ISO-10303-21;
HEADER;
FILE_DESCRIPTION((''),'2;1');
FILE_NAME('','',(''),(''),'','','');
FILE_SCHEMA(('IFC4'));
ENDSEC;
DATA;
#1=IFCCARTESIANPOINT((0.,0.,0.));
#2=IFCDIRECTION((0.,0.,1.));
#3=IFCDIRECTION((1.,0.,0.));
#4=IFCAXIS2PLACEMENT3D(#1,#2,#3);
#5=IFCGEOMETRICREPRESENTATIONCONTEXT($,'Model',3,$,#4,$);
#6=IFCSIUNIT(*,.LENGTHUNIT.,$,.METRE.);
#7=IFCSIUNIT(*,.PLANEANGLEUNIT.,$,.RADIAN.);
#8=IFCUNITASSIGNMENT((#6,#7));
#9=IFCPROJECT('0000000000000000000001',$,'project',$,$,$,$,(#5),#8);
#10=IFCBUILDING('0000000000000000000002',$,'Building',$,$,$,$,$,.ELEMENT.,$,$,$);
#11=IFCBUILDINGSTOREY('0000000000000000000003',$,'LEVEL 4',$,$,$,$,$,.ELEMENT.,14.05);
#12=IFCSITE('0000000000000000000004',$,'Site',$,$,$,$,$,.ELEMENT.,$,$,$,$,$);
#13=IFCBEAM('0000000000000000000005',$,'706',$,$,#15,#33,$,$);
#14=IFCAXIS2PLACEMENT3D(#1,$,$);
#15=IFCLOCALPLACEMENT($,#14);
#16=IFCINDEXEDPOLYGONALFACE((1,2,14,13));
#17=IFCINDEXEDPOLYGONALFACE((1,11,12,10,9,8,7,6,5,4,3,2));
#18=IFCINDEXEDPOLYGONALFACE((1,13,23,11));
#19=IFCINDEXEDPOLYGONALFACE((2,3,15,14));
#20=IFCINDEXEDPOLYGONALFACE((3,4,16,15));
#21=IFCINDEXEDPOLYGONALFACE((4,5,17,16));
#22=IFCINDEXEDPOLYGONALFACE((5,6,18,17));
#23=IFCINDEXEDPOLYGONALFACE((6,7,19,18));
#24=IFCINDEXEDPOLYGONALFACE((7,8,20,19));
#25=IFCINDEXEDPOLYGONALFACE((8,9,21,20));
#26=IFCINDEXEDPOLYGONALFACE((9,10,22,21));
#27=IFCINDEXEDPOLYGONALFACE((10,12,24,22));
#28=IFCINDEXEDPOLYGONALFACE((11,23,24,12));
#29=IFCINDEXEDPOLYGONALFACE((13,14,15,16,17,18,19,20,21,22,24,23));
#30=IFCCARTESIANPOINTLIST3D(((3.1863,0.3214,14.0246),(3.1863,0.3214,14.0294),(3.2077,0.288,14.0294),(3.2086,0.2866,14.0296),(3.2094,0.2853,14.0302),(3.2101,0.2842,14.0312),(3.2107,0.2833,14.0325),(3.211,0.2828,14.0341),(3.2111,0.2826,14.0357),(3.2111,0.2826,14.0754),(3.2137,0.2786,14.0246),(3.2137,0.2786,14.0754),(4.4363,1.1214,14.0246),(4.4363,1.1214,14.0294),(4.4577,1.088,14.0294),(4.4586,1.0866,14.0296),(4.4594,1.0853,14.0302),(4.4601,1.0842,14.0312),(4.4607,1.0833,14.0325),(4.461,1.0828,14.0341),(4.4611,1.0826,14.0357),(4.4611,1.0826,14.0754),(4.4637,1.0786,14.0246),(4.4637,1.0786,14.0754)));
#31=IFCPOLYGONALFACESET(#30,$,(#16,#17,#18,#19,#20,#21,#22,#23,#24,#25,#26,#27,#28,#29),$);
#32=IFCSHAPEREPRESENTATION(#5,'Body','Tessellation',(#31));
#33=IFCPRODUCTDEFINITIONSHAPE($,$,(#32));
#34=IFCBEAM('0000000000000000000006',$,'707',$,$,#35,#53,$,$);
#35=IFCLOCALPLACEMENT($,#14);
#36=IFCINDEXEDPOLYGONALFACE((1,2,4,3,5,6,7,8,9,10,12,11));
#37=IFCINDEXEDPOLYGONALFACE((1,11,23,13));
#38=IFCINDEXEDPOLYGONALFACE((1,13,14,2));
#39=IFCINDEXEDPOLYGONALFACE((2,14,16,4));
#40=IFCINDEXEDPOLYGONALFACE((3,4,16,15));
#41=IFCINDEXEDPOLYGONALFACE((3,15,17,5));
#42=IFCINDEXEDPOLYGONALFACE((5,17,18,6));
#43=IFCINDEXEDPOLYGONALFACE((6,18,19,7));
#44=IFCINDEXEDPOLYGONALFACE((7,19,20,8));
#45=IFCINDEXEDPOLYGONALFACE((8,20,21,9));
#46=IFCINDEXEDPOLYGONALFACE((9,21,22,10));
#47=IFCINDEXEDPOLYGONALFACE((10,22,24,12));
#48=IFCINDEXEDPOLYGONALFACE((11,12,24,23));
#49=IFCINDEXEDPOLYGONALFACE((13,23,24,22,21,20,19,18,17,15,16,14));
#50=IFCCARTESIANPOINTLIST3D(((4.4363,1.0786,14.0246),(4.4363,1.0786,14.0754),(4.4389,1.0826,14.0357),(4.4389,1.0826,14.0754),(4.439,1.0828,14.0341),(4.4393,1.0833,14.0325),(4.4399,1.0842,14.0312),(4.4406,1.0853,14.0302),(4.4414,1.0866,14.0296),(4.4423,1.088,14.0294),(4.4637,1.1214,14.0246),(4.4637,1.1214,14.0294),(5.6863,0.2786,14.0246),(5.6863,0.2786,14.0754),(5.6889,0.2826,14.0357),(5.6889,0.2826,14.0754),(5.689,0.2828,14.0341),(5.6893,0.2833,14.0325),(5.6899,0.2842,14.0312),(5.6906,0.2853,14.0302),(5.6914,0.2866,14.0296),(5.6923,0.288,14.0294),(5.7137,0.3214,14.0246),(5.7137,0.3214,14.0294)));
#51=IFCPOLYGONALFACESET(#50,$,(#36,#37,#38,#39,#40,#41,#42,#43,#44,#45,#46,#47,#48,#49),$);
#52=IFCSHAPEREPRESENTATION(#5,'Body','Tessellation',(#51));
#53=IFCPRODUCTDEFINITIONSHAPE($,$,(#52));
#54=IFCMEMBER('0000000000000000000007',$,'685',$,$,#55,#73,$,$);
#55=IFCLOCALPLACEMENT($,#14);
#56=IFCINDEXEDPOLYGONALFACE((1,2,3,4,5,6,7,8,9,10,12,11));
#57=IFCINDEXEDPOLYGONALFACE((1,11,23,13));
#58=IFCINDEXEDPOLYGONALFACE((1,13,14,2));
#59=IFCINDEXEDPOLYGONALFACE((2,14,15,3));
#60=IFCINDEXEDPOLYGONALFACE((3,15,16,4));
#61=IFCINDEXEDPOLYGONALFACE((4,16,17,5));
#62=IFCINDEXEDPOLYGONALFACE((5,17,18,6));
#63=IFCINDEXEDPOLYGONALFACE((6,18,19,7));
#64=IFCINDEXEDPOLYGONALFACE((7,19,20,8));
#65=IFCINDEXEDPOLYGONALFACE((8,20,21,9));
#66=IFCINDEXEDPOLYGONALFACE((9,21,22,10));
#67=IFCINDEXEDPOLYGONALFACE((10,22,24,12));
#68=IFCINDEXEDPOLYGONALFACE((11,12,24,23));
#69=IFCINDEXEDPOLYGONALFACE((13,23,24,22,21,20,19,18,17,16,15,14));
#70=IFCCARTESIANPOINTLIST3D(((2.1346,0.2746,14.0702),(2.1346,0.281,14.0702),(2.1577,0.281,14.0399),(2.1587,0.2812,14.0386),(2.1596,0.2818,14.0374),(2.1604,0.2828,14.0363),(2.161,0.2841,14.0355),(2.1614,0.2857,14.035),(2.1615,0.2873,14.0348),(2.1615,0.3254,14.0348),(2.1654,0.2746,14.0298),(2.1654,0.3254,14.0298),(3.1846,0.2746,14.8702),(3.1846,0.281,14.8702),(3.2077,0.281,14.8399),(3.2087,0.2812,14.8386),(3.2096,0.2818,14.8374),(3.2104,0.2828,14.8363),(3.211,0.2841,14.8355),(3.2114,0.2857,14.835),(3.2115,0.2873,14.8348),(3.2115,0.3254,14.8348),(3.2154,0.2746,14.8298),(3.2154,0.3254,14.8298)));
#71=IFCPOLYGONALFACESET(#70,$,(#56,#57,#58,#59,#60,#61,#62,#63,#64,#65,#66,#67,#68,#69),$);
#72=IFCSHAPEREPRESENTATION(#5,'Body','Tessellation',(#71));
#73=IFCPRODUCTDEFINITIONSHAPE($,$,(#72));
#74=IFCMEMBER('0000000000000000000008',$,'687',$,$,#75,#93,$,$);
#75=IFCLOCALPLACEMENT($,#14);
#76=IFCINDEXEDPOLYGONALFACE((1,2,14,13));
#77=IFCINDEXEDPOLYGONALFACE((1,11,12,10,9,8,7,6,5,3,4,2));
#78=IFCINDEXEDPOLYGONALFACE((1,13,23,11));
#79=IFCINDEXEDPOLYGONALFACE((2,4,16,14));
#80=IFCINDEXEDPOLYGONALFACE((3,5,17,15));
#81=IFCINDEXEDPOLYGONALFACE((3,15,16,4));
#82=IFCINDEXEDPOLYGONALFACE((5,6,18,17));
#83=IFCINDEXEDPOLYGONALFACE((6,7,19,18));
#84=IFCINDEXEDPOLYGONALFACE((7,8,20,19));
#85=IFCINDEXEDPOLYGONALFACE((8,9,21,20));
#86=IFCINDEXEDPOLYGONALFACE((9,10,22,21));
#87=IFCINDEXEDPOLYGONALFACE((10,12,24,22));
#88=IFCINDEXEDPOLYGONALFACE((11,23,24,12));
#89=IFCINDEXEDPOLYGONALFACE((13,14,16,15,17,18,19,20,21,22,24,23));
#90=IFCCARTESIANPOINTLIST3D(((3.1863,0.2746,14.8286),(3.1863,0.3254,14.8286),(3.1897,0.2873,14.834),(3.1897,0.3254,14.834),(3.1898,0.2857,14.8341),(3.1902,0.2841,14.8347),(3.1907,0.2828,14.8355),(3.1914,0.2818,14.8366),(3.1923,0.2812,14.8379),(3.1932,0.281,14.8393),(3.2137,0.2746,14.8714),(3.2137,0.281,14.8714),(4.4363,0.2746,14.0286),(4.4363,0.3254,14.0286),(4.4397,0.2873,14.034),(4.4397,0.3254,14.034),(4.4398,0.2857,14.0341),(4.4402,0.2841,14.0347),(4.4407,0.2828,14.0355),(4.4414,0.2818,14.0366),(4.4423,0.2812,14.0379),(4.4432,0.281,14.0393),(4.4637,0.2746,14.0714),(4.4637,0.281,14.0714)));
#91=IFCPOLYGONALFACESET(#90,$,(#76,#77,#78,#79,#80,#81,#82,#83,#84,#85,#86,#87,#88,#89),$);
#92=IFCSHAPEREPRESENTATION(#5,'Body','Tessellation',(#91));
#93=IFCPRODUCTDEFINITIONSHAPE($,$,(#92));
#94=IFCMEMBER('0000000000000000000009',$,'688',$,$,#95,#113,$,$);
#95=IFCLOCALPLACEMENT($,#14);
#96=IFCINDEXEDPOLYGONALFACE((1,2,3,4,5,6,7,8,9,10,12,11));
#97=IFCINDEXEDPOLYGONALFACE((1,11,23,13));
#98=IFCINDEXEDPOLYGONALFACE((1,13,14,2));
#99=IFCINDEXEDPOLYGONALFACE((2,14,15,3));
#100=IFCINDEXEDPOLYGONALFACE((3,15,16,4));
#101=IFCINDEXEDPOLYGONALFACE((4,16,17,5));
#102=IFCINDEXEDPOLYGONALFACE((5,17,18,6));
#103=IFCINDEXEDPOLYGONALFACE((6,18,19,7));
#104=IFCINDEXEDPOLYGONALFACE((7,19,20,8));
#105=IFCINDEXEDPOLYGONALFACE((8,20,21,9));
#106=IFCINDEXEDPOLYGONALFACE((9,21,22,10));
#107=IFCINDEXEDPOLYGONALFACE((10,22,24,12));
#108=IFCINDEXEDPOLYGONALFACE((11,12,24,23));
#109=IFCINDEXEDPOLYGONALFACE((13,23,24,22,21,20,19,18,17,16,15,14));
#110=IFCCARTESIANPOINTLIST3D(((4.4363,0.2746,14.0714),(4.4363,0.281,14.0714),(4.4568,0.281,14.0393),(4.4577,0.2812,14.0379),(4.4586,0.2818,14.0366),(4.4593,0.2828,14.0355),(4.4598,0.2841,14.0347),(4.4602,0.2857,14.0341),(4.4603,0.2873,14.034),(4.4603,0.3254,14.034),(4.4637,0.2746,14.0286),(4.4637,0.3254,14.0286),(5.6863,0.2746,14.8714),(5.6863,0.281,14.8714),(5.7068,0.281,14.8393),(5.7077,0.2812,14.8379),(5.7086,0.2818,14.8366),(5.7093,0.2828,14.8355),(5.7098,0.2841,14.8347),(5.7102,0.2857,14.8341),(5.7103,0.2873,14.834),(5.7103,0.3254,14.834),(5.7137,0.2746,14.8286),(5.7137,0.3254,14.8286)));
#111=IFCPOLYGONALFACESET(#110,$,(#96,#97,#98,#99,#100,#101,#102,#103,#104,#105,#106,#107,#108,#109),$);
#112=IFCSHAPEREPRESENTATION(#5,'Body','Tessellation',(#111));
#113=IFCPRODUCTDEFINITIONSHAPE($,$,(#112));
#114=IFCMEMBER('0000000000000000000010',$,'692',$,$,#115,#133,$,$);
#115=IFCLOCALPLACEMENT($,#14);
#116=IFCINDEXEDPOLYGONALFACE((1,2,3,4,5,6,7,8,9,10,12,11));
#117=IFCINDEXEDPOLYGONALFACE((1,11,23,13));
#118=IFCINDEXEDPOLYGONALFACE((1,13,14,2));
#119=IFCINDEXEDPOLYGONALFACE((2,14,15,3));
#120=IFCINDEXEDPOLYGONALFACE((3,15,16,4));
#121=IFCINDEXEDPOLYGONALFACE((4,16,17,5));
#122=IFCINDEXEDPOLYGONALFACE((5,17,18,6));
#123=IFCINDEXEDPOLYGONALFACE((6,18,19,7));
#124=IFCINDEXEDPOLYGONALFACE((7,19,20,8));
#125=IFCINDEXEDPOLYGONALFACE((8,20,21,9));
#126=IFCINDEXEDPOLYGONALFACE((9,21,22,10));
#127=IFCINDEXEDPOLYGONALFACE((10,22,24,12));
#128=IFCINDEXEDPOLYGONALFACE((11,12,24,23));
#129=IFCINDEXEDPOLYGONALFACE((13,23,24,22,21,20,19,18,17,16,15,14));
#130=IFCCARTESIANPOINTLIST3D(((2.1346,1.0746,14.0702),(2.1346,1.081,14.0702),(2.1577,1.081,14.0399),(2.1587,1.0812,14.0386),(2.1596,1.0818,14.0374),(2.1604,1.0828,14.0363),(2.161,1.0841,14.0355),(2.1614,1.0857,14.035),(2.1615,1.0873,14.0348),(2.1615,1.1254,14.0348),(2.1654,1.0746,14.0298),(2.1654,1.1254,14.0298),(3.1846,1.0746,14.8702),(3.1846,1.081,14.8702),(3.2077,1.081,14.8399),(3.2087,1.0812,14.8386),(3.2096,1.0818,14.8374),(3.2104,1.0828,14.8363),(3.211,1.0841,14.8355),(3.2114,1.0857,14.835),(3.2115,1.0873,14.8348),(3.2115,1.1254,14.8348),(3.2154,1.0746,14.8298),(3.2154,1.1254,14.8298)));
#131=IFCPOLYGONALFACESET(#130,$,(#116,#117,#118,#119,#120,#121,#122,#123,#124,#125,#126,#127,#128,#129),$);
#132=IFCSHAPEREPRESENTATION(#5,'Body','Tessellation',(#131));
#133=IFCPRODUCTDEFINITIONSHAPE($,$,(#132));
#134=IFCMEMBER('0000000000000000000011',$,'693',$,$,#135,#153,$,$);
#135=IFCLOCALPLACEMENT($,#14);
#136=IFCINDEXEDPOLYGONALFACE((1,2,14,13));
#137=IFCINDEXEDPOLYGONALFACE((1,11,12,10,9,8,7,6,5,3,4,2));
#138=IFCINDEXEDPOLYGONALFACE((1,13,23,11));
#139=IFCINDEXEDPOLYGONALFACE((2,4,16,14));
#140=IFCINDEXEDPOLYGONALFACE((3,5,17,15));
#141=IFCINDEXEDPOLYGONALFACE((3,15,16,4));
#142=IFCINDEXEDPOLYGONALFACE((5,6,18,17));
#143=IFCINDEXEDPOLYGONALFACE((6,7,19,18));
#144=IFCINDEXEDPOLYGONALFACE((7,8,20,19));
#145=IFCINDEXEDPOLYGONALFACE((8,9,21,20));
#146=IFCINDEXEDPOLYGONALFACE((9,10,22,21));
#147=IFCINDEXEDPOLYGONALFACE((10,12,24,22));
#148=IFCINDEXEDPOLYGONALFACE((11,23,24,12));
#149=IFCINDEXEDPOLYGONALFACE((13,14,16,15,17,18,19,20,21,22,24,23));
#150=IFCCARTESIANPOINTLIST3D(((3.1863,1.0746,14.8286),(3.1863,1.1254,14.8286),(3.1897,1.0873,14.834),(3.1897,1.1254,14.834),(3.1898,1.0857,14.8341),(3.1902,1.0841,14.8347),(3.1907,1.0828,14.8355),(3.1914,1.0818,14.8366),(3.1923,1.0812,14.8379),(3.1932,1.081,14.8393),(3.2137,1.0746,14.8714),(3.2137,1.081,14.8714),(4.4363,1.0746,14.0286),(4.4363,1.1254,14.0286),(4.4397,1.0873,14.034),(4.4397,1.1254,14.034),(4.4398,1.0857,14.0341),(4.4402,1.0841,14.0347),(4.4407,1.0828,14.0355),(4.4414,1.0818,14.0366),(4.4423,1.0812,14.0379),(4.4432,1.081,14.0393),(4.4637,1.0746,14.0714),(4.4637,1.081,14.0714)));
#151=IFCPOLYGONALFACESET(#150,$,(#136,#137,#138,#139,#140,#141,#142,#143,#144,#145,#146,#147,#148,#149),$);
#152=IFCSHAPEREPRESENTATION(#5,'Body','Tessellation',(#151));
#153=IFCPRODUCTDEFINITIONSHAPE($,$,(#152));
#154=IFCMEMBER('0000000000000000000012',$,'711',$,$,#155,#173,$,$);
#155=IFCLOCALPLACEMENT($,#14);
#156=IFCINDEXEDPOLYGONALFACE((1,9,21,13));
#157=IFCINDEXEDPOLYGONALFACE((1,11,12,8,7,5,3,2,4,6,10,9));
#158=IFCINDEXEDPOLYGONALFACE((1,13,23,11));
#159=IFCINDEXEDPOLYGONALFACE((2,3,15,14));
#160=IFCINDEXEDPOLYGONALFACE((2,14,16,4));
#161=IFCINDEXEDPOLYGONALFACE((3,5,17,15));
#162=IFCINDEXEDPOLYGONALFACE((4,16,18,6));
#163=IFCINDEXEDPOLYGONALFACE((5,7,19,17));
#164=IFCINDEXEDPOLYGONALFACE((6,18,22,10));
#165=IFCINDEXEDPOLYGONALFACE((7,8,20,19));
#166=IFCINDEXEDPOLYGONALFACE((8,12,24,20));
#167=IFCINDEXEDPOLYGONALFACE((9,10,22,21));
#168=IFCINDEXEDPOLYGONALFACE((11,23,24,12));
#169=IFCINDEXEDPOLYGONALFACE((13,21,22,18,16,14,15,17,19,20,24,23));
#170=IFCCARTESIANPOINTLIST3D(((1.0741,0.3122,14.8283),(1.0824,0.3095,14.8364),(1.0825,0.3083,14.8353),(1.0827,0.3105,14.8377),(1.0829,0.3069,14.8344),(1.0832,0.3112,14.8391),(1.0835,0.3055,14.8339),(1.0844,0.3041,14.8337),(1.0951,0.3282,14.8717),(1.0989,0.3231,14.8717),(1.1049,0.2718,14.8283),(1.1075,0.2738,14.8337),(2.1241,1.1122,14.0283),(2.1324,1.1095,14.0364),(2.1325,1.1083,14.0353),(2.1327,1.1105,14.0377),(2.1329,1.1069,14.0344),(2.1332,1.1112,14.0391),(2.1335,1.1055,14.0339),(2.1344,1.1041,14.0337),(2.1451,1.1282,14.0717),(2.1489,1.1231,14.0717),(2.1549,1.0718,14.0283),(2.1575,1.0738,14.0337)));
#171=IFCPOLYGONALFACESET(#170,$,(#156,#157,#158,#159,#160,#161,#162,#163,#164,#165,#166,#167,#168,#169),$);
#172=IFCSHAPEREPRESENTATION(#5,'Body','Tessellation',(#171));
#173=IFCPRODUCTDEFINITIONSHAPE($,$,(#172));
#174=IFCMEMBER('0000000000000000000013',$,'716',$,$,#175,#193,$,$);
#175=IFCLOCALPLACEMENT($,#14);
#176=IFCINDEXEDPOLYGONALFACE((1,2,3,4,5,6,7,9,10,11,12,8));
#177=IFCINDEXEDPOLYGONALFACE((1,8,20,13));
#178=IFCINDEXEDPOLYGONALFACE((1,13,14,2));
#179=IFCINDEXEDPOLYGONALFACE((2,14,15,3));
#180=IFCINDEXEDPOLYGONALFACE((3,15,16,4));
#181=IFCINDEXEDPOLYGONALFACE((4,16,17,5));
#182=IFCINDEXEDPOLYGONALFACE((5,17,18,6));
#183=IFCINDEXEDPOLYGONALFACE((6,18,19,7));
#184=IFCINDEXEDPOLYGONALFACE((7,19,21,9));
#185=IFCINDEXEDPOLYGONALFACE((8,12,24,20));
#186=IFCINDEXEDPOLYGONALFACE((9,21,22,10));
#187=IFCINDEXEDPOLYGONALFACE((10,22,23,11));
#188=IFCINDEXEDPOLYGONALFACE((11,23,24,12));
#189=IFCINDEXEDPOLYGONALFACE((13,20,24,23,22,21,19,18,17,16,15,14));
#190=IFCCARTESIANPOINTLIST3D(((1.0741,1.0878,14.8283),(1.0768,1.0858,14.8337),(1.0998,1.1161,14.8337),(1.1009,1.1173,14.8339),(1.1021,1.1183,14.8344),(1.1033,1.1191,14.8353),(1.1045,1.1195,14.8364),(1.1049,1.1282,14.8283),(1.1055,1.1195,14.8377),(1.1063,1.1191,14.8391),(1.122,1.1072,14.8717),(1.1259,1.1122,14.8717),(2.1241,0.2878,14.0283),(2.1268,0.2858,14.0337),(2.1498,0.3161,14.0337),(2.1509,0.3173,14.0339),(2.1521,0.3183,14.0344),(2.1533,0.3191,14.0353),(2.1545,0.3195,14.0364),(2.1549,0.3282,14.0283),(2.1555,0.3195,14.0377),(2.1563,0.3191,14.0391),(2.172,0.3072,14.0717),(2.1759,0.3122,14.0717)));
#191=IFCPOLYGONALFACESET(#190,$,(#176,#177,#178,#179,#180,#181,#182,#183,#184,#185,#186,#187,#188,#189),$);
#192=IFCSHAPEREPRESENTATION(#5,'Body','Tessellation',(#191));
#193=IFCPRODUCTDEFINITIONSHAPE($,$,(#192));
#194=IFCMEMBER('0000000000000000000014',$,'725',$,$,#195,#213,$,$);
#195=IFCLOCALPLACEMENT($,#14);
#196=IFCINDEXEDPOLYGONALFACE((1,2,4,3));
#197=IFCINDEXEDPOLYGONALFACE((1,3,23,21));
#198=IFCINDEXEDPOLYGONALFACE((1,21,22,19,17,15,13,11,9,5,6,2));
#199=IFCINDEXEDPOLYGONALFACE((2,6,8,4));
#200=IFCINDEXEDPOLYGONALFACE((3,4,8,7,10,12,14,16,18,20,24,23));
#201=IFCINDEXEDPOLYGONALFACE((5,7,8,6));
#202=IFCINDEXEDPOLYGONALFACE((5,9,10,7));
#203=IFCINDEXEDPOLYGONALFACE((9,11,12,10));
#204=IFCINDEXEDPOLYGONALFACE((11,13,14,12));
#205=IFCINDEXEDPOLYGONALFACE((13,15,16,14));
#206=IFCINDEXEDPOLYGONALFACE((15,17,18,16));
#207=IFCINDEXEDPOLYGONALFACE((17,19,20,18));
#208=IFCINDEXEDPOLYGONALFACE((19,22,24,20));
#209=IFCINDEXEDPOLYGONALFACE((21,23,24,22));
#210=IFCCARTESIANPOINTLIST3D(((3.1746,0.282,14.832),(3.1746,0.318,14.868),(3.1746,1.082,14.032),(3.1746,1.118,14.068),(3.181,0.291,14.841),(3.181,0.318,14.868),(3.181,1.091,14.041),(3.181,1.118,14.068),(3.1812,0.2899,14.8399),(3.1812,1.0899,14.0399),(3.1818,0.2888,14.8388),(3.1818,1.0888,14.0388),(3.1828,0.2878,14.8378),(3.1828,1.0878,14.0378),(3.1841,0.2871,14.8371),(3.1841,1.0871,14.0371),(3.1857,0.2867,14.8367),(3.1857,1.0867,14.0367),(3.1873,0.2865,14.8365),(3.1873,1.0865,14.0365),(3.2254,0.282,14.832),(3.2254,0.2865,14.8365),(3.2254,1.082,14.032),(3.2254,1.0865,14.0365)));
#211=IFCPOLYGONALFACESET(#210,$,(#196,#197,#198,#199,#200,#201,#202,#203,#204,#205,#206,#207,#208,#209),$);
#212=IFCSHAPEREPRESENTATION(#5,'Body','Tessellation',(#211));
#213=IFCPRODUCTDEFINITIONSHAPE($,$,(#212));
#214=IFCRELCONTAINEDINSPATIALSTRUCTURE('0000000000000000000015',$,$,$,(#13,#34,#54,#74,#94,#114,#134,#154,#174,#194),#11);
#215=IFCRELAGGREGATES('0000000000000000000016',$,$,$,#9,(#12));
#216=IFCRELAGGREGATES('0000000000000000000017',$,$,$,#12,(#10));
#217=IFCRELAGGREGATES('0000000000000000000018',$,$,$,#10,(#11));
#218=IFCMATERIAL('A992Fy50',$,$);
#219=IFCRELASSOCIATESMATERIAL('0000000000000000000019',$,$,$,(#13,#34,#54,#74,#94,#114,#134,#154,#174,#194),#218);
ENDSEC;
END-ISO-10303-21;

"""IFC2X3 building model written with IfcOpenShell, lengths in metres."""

from ifc_helpers import new_model, si_unit, frame, origin_with_axes, origin_2d_with_axis, place, context, project, spatial, l_section, extrude, material, element, save


model = new_model("IFC2X3")

# Units and contexts
model_context = context("Model", 3, world=origin_with_axes())
ifc_project = project(units=[si_unit("LENGTHUNIT", "METRE"), si_unit("PLANEANGLEUNIT", "RADIAN")], contexts=[model_context])

# Site, building, storey
site = spatial("IfcSite", under=ifc_project, Name="Site", CompositionType="ELEMENT")
building = spatial("IfcBuilding", under=site, Name="Building", CompositionType="ELEMENT")
storey = spatial("IfcBuildingStorey", under=building, Name="LEVEL 4", CompositionType="ELEMENT", Elevation=14.05)

# Shared definitions
ifc_material = material(Name="A992Fy50")

# Beams
for number, where, z_axis, x_axis, name in (
    (1, (3.2, 0.3, 14.05), (0.842271, 0.539054, 0.0), (-0.539054, 0.842271, 0.0), "706"),
    (2, (4.45, 1.1, 14.05), (0.842271, -0.539054, 0.0), (0.539054, 0.842271, 0.0), "707"),
):
    element("IfcBeam", number, at=place(None, frame(where, z_axis=z_axis, x_axis=x_axis)), inside=storey, material=ifc_material, Name=name, context=model_context, shape_type="SweptSolid", body=[
        extrude(l_section(Depth=0.0508, Width=0.0508, Thickness=0.0048, FilletRadius=0.0063, at=origin_2d_with_axis()), origin_with_axes(), (0.0, 0.0, 1.0), 1.4841),
    ])

# Members
member_1_placement = place(None, frame((2.15, 0.3, 14.05), z_axis=(0.795432, 0.0, 0.606043), x_axis=(0.0, 1.0, 0.0)))
element("IfcMember", 3, at=member_1_placement, inside=storey, material=ifc_material, Name="685", context=model_context, shape_type="SweptSolid", body=[
    extrude(l_section(Depth=0.0508, Width=0.0508, Thickness=0.0063, FilletRadius=0.0063, at=origin_2d_with_axis()), origin_with_axes(), (0.0, 0.0, 1.0), 1.32),
])
for number, where, z_axis, x_axis, name in (
    (4, (3.2, 0.3, 14.85), (0.842271, 0.0, -0.539054), (0.0, 1.0, 0.0), "687"),
    (5, (4.45, 0.3, 14.05), (0.842271, 0.0, 0.539054), (0.0, 1.0, 0.0), "688"),
):
    element("IfcMember", number, at=place(None, frame(where, z_axis=z_axis, x_axis=x_axis)), inside=storey, material=ifc_material, Name=name, context=model_context, shape_type="SweptSolid", body=[
        extrude(l_section(Depth=0.0508, Width=0.0508, Thickness=0.0063, FilletRadius=0.0063, at=origin_2d_with_axis()), origin_with_axes(), (0.0, 0.0, 1.0), 1.4841),
    ])
member_2_placement = place(None, frame((2.15, 1.1, 14.05), z_axis=(0.795432, 0.0, 0.606043), x_axis=(0.0, 1.0, 0.0)))
element("IfcMember", 6, at=member_2_placement, inside=storey, material=ifc_material, Name="692", context=model_context, shape_type="SweptSolid", body=[
    extrude(l_section(Depth=0.0508, Width=0.0508, Thickness=0.0063, FilletRadius=0.0063, at=origin_2d_with_axis()), origin_with_axes(), (0.0, 0.0, 1.0), 1.32),
])
member_3_placement = place(None, frame((3.2, 1.1, 14.85), z_axis=(0.842271, 0.0, -0.539054), x_axis=(0.0, 1.0, 0.0)))
element("IfcMember", 7, at=member_3_placement, inside=storey, material=ifc_material, Name="693", context=model_context, shape_type="SweptSolid", body=[
    extrude(l_section(Depth=0.0508, Width=0.0508, Thickness=0.0063, FilletRadius=0.0063, at=origin_2d_with_axis()), origin_with_axes(), (0.0, 0.0, 1.0), 1.4841),
])
for number, where, z_axis, x_axis, name in (
    (8, (2.15, 1.1, 14.05), (-0.680257, -0.518291, 0.518291), (0.606043, -0.795432, 0.0), "711"),
    (9, (2.15, 0.3, 14.05), (-0.680257, 0.518291, 0.518291), (-0.606043, -0.795432, 0.0), "716"),
):
    element("IfcMember", number, at=place(None, frame(where, z_axis=z_axis, x_axis=x_axis)), inside=storey, material=ifc_material, Name=name, context=model_context, shape_type="SweptSolid", body=[
        extrude(l_section(Depth=0.0508, Width=0.0508, Thickness=0.0063, FilletRadius=0.0063, at=origin_2d_with_axis()), origin_with_axes(), (0.0, 0.0, 1.0), 1.5435),
    ])
for number, where, z_axis, x_axis, name in (
    (10, (3.2, 1.1, 14.05), (0.0, -0.707107, 0.707107), (1.0, 0.0, 0.0), "725"),
):
    element("IfcMember", number, at=place(None, frame(where, z_axis=z_axis, x_axis=x_axis)), inside=storey, material=ifc_material, Name=name, context=model_context, shape_type="SweptSolid", body=[
        extrude(l_section(Depth=0.0508, Width=0.0508, Thickness=0.0063, FilletRadius=0.0063, at=origin_2d_with_axis()), origin_with_axes(), (0.0, 0.0, 1.0), 1.1314),
    ])

save(model, "model.ifc")
